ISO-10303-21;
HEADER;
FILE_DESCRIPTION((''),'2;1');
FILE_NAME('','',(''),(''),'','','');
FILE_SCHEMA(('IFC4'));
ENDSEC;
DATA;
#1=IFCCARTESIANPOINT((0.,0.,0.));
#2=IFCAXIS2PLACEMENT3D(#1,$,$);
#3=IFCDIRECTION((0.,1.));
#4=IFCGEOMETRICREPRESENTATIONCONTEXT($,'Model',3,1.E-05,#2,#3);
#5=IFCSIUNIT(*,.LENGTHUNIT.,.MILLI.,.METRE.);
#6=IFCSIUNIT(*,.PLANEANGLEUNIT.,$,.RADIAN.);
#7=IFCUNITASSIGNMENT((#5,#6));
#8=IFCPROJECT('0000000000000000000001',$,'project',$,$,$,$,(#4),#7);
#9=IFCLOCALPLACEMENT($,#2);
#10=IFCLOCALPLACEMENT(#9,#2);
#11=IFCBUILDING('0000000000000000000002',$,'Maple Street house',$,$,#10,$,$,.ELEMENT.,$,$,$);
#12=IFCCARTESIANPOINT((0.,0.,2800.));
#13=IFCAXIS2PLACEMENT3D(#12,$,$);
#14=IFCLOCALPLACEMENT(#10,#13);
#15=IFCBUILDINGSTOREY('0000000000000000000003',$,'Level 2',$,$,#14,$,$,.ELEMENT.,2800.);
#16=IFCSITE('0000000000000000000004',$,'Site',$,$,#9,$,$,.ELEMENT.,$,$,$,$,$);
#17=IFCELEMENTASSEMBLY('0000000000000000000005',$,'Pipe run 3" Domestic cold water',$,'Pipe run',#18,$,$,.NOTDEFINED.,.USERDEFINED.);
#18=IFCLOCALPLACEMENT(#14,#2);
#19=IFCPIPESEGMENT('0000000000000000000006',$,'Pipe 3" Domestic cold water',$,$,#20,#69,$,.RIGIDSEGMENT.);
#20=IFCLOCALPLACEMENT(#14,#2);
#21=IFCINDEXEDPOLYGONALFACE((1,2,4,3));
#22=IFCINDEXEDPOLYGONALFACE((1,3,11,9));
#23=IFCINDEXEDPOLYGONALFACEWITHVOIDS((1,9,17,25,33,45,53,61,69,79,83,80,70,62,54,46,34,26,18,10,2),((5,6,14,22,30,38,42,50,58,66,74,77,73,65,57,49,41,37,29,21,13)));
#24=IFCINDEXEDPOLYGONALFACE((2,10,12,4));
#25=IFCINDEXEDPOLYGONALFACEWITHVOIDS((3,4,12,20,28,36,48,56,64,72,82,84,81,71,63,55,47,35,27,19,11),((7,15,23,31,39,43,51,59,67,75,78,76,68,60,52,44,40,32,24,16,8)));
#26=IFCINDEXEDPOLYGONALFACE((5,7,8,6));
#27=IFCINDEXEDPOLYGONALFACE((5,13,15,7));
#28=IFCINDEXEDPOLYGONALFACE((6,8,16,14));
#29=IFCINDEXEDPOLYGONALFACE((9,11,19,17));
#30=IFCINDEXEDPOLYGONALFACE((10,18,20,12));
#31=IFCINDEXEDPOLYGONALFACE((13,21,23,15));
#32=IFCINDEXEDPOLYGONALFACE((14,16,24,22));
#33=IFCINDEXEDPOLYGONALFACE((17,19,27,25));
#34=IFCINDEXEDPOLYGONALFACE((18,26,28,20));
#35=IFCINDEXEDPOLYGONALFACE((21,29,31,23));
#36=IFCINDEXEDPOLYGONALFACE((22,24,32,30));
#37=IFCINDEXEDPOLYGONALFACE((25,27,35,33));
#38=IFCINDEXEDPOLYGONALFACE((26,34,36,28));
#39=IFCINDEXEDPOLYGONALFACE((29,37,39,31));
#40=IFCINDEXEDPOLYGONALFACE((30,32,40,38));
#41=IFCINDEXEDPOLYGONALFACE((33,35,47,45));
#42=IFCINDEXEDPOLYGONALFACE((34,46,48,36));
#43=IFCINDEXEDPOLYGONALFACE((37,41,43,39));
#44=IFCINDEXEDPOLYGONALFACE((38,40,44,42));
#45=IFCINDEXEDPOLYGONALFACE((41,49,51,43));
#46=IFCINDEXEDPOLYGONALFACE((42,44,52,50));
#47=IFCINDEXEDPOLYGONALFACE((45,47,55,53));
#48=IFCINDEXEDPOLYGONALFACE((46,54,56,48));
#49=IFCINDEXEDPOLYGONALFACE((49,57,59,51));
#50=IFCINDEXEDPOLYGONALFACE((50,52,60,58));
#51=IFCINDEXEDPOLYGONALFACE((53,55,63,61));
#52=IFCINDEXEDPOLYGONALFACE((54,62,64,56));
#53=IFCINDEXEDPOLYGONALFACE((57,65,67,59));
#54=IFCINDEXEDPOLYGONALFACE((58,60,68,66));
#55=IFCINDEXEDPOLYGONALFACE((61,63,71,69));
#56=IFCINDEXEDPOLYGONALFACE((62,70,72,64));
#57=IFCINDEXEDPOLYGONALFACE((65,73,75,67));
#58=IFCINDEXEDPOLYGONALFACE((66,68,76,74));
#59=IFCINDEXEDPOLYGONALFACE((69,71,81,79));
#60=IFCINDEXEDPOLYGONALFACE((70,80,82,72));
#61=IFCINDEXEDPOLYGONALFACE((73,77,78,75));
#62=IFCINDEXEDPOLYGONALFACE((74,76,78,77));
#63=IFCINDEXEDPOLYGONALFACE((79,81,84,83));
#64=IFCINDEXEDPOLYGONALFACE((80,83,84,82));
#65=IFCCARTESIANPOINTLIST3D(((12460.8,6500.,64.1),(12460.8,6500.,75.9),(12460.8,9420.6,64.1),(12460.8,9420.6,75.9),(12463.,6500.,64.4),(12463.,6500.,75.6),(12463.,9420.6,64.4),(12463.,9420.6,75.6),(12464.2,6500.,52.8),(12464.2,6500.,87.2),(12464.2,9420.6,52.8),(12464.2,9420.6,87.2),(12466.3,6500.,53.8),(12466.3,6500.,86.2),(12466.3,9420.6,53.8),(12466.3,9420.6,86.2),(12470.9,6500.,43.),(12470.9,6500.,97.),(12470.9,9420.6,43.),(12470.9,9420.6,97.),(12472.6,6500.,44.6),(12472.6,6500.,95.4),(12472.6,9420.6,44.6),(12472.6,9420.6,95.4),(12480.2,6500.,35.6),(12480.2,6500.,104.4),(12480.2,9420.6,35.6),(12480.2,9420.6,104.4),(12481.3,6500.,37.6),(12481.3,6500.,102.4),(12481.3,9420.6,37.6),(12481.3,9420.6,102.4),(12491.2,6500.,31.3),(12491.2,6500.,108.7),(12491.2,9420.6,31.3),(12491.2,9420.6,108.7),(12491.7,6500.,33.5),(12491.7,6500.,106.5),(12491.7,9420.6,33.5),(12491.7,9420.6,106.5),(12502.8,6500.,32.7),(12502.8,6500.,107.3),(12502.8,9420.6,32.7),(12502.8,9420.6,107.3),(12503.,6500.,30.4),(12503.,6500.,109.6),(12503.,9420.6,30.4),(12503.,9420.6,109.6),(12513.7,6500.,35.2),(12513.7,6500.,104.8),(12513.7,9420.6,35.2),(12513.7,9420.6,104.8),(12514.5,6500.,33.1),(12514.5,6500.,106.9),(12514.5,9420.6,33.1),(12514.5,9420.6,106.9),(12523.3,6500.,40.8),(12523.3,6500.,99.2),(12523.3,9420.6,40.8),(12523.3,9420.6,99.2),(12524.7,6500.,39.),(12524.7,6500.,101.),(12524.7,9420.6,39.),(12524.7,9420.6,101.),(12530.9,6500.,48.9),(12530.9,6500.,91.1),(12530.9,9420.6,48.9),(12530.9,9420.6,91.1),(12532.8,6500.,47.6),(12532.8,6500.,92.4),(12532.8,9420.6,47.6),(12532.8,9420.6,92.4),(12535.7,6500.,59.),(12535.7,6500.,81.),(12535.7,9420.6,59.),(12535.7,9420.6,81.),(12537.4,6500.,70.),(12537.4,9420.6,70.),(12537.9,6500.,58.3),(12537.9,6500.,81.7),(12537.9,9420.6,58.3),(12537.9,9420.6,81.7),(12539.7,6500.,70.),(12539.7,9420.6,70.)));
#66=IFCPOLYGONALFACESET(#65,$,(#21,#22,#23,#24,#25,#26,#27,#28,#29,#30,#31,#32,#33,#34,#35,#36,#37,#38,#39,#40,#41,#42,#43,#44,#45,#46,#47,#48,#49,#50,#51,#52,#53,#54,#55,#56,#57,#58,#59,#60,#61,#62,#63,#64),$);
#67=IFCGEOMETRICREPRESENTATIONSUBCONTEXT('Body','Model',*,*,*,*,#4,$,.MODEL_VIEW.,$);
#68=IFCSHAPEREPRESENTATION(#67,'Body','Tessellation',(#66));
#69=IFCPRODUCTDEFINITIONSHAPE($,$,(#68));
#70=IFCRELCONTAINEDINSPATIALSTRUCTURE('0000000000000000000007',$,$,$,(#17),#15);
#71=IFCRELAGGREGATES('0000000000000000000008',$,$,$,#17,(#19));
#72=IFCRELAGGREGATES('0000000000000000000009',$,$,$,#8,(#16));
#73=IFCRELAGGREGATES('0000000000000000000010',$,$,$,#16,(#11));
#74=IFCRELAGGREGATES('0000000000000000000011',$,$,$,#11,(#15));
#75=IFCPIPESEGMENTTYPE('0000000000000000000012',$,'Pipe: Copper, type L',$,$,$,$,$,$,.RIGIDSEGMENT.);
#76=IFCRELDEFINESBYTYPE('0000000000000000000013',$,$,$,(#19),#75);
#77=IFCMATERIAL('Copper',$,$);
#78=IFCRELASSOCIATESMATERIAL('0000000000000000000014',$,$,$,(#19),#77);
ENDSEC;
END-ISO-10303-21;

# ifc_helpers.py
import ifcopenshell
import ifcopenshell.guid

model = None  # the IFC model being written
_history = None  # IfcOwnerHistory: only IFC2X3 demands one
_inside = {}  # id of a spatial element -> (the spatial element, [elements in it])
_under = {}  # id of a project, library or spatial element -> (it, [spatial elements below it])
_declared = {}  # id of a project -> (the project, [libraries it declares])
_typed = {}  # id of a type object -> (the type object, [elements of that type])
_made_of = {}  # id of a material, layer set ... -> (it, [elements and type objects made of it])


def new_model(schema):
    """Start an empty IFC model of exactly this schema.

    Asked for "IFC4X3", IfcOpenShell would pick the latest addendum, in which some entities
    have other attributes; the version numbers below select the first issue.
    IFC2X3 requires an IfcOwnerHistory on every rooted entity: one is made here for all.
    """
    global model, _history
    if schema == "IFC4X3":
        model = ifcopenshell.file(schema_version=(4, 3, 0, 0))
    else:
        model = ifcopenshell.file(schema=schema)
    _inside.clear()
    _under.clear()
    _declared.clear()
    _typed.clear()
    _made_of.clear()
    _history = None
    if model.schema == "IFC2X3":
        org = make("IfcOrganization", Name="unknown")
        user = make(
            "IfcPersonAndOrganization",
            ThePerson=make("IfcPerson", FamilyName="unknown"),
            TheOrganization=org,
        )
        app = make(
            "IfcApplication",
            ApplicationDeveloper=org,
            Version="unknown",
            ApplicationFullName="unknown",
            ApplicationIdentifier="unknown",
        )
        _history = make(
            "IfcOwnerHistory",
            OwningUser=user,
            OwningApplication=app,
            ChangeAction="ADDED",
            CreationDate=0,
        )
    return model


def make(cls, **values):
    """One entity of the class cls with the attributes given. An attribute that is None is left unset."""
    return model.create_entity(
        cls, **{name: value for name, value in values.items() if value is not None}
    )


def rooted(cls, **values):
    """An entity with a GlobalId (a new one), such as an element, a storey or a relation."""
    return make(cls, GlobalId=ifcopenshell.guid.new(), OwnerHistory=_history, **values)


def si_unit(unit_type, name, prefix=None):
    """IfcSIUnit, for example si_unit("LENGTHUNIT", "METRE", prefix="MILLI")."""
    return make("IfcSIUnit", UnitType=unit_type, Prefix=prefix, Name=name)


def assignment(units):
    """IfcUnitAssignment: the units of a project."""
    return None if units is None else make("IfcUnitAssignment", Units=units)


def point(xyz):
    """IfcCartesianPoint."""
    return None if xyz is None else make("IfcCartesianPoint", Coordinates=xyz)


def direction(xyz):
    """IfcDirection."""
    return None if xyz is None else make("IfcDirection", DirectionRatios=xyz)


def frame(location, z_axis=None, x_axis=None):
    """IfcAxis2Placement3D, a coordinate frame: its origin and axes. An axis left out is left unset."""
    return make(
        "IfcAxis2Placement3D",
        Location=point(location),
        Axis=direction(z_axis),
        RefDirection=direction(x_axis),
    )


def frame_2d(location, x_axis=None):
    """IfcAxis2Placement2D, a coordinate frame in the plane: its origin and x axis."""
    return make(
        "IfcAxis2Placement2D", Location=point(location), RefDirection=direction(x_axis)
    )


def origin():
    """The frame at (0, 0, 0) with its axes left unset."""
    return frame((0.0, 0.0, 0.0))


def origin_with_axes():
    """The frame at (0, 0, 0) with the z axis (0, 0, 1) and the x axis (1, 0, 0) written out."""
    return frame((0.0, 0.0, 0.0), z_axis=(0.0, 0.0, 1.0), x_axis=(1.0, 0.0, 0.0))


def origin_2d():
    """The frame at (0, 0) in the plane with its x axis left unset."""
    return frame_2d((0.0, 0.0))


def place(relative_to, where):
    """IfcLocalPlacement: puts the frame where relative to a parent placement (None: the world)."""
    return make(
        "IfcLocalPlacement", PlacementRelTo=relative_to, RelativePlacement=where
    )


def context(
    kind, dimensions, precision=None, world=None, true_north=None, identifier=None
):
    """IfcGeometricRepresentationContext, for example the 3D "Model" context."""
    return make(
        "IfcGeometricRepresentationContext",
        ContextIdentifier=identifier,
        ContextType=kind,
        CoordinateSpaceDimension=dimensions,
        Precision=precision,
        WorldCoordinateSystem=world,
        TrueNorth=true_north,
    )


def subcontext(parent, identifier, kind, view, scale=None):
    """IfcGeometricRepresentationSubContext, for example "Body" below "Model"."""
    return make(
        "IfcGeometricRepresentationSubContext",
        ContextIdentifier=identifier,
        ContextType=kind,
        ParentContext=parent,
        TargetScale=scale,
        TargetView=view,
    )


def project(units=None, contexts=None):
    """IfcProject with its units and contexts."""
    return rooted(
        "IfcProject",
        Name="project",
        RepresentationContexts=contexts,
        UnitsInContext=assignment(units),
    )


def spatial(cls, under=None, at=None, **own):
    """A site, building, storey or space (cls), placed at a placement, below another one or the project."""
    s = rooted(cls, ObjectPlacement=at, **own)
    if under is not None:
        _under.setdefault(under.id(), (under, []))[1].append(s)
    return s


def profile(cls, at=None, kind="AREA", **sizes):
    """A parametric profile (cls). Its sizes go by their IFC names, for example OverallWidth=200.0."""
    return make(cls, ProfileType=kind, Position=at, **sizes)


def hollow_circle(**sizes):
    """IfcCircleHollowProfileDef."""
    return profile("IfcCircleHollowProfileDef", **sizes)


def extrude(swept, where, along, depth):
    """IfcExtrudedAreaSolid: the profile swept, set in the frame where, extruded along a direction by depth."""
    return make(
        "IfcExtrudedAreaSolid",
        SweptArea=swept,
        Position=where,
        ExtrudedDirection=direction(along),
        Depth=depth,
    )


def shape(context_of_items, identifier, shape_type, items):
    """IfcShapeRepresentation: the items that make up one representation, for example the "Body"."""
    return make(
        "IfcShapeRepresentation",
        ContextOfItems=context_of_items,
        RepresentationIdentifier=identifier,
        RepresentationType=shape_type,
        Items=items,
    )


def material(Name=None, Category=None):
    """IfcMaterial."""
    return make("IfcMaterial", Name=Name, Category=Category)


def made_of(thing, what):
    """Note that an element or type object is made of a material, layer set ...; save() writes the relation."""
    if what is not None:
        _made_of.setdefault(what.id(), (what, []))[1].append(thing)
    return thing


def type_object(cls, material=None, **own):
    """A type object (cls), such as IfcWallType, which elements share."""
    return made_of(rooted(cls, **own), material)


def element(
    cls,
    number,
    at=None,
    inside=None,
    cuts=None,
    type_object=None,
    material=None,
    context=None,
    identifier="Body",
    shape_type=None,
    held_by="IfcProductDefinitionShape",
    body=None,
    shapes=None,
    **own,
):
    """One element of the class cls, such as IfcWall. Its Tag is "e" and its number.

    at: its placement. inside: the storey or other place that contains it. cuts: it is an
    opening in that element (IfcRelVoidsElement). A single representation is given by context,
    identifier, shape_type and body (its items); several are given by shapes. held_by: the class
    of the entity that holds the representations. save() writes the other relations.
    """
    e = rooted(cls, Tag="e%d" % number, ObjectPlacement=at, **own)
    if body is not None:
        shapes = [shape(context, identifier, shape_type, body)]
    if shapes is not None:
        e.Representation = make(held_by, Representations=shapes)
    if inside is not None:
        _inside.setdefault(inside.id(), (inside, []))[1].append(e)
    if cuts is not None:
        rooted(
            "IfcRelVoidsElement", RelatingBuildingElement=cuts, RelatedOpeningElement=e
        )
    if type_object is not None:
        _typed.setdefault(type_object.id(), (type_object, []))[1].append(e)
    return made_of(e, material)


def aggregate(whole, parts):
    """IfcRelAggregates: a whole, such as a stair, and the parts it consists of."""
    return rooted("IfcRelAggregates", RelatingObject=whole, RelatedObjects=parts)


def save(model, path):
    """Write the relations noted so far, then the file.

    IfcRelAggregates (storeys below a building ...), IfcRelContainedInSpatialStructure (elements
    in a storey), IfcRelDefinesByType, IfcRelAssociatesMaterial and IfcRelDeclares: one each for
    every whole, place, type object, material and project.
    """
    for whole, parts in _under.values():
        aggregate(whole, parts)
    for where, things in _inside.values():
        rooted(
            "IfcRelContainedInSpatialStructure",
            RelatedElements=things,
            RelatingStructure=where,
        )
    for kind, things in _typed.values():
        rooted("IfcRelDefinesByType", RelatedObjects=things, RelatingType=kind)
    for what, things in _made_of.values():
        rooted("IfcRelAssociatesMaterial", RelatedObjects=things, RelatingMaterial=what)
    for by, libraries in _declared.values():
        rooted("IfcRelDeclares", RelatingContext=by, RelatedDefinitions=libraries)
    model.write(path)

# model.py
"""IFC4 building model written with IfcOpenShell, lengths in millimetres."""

from ifc_helpers import new_model, si_unit, direction, frame, origin, origin_with_axes, origin_2d, place, context, subcontext, project, spatial, hollow_circle, extrude, material, type_object, element, aggregate, save


model = new_model("IFC4")

# Units and contexts
model_context = context("Model", 3, precision=1e-05, world=origin(), true_north=direction((0.0, 1.0)))
body_context = subcontext(model_context, "Body", "Model", "MODEL_VIEW")
ifc_project = project(units=[si_unit("LENGTHUNIT", "METRE", prefix="MILLI"), si_unit("PLANEANGLEUNIT", "RADIAN")], contexts=[model_context])

# Site, building, storey
site_placement = place(None, origin())
site = spatial("IfcSite", under=ifc_project, at=site_placement, Name="Site", CompositionType="ELEMENT")
building_placement = place(site_placement, origin())
building = spatial("IfcBuilding", under=site, at=building_placement, Name="Maple Street house", CompositionType="ELEMENT")
storey_placement = place(building_placement, frame((0.0, 0.0, 2800.0)))
storey = spatial("IfcBuildingStorey", under=building, at=storey_placement, Name="Level 2", CompositionType="ELEMENT", Elevation=2800.0)

# Element assembly, pipe segment
assembly_placement = place(storey_placement, origin_with_axes())
assembly = element("IfcElementAssembly", 1, at=assembly_placement, inside=storey, Name="Pipe run 3\" Domestic cold water", ObjectType="Pipe run", AssemblyPlace="NOTDEFINED", PredefinedType="USERDEFINED")
ifc_material = material(Name="Copper")
pipe_segment_type = type_object("IfcPipeSegmentType", Name="Pipe: Copper, type L", PredefinedType="RIGIDSEGMENT")
pipe_segment_1_placement = place(storey_placement, origin_with_axes())
pipe_segment_1 = element("IfcPipeSegment", 2, at=pipe_segment_1_placement, type_object=pipe_segment_type, material=ifc_material, Name="Pipe 3\" Domestic cold water", PredefinedType="RIGIDSEGMENT", context=body_context, shape_type="SweptSolid", body=[
    extrude(hollow_circle(Radius=39.7, WallThickness=2.3, at=origin_2d()), frame((12500.0, 9420.6, 70.0), z_axis=(0.0, -1.0, 0.0), x_axis=(1.0, 0.0, 0.0)), (0.0, 0.0, 1.0), 2920.6),
])
aggregate(assembly, [pipe_segment_1])

save(model, "model.ifc")
